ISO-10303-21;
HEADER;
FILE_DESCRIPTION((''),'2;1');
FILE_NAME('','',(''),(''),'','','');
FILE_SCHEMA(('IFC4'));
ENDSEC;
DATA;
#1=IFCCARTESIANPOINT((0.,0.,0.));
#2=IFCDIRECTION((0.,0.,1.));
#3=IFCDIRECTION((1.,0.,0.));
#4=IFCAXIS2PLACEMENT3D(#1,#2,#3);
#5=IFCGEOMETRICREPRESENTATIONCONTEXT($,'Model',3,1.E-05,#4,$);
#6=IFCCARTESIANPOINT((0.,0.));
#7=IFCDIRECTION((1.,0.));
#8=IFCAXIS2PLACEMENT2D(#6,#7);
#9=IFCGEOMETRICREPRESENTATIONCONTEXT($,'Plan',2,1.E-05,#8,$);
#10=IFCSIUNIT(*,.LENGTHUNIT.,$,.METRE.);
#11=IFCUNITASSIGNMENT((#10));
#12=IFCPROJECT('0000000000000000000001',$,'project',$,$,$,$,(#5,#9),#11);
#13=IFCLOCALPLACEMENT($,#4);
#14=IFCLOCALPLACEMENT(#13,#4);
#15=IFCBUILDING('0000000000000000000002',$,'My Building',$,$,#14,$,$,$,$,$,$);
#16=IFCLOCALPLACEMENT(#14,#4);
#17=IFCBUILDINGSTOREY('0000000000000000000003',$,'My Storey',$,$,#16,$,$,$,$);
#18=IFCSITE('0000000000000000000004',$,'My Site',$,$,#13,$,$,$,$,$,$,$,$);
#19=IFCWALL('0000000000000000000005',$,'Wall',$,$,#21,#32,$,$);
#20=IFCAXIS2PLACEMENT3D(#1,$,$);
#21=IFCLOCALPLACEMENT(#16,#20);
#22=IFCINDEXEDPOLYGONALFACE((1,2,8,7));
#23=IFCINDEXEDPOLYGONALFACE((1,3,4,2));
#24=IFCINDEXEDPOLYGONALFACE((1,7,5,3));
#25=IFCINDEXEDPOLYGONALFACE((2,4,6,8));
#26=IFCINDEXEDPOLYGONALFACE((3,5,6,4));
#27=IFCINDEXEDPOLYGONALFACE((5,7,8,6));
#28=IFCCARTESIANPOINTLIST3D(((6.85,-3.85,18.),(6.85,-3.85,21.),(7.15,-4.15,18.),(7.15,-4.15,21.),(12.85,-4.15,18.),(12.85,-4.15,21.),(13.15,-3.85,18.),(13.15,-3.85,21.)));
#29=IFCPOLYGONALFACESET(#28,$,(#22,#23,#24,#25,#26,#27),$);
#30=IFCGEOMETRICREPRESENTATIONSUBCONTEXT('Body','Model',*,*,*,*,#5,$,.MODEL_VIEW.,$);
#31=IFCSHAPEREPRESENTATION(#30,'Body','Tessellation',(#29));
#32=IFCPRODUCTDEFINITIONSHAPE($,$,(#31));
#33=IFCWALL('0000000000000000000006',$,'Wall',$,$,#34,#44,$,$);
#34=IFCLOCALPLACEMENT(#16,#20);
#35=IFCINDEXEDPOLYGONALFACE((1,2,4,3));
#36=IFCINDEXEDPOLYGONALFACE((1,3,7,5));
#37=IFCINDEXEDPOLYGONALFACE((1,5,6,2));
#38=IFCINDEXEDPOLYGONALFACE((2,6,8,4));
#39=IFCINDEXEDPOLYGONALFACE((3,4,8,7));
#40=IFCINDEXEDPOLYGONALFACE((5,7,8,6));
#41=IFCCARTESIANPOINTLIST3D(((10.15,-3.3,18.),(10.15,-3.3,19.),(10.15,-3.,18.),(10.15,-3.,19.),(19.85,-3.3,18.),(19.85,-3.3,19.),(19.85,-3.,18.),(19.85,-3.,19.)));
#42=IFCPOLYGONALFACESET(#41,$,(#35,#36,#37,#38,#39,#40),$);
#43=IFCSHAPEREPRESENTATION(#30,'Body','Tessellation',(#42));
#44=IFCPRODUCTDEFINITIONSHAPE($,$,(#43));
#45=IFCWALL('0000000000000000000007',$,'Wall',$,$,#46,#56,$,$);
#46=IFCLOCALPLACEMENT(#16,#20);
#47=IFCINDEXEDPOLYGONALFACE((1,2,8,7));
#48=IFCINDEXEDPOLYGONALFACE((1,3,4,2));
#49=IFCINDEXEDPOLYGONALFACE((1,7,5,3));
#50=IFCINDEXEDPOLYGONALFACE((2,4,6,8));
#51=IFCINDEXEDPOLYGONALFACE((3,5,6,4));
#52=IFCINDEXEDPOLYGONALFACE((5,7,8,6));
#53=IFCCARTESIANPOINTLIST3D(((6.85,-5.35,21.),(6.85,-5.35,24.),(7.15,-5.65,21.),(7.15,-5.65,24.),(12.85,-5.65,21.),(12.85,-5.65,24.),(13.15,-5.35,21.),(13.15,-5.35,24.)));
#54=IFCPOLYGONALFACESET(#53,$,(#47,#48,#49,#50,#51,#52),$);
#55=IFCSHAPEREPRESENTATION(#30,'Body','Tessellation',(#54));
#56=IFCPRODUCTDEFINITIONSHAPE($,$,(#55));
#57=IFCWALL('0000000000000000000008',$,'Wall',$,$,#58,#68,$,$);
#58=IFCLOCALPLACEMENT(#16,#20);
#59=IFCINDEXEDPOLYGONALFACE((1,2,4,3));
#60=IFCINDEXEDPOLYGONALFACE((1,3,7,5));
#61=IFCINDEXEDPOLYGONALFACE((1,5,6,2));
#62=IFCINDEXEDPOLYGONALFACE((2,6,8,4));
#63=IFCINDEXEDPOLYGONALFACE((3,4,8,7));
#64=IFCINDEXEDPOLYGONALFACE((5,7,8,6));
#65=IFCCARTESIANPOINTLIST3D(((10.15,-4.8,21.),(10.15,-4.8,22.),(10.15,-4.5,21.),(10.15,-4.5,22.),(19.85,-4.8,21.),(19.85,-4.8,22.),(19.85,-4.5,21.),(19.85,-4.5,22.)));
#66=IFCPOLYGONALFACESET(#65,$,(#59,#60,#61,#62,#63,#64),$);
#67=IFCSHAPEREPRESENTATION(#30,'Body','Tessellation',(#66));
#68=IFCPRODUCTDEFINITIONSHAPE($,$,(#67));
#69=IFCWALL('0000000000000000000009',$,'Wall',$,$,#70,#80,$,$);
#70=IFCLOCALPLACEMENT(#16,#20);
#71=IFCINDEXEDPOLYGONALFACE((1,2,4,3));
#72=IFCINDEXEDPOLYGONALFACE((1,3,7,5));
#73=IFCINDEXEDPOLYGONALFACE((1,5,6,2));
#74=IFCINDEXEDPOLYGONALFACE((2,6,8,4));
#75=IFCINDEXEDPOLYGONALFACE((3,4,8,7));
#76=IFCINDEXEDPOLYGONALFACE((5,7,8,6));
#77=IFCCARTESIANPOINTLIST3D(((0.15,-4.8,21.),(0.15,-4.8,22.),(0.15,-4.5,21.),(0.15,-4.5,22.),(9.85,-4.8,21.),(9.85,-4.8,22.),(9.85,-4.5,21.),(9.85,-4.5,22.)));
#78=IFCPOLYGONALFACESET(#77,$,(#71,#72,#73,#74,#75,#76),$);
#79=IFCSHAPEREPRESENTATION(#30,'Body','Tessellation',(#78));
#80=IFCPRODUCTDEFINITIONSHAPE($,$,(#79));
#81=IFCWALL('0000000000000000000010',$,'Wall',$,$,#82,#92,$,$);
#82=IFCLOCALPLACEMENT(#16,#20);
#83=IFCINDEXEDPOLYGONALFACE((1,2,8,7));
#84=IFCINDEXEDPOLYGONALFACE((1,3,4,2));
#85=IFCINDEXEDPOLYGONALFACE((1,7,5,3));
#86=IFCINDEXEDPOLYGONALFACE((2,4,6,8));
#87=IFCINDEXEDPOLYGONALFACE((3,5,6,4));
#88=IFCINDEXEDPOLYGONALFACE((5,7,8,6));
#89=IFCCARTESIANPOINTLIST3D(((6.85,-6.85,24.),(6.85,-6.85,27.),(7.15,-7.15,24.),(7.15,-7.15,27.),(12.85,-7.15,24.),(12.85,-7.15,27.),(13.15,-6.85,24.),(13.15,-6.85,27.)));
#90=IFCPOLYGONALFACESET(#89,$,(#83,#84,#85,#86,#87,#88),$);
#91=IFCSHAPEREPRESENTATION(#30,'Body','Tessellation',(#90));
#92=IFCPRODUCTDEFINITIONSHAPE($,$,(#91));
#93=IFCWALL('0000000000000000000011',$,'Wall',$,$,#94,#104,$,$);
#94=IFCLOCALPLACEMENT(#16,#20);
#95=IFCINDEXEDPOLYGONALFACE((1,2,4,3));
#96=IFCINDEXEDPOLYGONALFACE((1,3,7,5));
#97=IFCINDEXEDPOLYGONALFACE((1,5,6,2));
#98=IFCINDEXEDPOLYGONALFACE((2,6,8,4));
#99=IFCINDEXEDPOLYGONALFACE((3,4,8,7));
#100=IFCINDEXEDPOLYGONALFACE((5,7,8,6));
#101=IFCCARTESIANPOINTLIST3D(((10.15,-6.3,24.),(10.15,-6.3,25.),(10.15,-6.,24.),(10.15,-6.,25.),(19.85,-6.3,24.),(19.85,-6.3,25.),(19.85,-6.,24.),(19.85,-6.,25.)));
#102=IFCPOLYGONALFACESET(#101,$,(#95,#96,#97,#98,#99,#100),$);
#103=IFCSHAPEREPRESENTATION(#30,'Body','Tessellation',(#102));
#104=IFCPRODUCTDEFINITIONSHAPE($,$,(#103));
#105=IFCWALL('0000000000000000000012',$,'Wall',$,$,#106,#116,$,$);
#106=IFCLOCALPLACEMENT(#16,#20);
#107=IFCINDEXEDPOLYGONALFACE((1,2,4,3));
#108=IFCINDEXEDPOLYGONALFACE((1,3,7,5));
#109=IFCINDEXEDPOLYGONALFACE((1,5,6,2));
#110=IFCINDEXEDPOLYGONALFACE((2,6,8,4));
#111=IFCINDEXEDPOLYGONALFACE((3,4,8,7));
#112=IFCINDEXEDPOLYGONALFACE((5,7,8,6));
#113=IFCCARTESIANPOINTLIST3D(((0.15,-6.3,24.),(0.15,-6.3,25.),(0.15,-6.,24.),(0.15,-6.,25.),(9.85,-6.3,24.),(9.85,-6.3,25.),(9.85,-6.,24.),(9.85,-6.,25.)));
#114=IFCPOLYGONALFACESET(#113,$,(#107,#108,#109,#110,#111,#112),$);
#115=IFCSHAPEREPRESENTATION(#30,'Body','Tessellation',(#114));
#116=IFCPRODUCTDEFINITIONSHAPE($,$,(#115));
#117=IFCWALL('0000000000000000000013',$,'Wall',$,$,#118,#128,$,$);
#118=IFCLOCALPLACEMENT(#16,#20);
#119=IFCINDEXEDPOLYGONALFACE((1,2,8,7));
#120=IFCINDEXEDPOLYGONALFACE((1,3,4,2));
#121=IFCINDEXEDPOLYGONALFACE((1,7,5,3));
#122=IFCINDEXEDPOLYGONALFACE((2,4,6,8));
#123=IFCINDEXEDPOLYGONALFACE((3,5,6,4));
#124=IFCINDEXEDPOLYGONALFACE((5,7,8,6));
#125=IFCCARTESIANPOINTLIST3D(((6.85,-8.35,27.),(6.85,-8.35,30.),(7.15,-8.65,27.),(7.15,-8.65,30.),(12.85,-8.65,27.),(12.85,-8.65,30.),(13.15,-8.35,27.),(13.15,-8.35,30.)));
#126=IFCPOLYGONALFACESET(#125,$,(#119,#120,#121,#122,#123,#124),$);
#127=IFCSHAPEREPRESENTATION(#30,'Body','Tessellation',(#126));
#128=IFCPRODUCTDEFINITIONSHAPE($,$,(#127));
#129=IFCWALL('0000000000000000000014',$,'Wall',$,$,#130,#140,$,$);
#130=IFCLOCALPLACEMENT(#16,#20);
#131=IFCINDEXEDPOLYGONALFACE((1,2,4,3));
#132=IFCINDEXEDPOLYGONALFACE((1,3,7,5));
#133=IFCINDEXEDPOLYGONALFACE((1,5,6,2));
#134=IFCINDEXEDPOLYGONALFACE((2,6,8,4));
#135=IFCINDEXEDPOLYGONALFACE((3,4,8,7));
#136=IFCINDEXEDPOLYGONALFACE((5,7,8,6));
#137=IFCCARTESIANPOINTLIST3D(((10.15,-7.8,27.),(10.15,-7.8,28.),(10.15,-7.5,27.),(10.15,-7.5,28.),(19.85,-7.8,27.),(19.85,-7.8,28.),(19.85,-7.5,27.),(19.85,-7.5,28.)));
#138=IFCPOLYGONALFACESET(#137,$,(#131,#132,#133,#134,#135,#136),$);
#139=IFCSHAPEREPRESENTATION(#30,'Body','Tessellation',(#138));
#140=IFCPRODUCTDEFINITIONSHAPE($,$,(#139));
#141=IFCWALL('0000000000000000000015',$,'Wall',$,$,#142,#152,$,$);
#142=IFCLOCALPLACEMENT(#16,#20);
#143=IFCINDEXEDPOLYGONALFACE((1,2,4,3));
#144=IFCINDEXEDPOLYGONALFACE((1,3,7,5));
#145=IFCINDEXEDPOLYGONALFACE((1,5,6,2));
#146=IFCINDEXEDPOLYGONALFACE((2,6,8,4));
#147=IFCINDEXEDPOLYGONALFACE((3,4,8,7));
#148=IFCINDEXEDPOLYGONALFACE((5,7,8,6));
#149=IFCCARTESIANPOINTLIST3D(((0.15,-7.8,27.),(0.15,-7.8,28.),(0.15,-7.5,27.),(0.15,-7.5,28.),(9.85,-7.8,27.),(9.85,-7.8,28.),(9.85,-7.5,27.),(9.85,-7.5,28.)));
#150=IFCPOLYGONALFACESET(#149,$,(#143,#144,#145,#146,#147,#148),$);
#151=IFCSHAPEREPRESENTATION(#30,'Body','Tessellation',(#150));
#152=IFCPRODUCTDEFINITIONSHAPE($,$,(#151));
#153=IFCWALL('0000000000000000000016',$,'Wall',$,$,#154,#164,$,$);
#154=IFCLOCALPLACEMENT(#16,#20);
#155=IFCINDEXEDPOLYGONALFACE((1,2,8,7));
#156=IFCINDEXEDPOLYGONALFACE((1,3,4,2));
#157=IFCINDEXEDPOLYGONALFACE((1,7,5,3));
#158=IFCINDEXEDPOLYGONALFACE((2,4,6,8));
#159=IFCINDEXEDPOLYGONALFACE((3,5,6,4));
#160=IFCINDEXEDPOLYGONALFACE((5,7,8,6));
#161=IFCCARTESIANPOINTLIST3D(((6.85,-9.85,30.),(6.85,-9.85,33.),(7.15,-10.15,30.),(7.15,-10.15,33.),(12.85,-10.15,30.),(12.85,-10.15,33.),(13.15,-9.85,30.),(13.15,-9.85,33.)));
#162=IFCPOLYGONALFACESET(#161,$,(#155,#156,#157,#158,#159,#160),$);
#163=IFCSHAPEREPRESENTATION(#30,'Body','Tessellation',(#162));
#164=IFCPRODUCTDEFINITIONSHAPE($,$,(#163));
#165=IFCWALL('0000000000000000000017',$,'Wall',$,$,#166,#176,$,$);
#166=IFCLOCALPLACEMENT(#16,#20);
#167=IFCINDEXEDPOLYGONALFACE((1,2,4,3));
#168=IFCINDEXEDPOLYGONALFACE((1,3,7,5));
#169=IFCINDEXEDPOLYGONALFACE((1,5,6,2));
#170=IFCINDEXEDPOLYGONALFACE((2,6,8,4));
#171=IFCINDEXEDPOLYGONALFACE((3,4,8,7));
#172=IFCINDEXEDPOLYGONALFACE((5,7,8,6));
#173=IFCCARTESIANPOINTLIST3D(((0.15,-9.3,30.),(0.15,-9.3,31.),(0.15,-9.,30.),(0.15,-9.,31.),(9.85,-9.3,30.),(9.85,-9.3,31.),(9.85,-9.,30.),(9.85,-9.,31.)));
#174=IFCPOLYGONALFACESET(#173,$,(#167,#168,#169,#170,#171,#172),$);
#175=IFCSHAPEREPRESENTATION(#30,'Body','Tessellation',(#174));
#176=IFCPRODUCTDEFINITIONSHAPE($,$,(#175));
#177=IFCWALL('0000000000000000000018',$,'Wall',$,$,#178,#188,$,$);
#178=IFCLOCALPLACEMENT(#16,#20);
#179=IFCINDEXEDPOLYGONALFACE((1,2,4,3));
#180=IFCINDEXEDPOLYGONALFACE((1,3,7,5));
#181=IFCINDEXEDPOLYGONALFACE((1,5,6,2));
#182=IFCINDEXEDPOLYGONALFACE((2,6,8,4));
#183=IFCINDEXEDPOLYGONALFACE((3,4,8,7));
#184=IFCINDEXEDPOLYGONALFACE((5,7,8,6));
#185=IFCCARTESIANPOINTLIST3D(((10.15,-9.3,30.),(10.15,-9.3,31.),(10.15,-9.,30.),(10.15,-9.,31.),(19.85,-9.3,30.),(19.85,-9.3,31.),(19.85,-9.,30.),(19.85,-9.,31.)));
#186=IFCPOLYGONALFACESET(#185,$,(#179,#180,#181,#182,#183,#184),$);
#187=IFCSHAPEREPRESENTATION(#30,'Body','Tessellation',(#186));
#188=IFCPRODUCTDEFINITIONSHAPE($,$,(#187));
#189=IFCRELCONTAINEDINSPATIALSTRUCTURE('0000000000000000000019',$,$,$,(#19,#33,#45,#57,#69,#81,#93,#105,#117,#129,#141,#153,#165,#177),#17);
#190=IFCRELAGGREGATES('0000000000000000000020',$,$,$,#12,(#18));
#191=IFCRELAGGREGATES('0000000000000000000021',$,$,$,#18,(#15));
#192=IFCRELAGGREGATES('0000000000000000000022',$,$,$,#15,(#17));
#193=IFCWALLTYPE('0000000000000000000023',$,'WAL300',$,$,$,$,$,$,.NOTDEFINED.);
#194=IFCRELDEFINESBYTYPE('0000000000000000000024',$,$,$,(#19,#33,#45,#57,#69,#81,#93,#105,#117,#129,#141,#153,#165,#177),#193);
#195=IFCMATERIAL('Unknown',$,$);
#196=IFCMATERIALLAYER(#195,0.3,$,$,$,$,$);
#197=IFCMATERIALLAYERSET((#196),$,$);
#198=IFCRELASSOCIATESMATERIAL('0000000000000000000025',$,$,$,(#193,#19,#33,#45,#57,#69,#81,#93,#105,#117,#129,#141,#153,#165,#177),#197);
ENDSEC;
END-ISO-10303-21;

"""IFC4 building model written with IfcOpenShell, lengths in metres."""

from ifc_helpers import new_model, si_unit, frame, origin_with_axes, origin_2d_with_axis, place, context, subcontext, project, spatial, line, indexed_curve, outline, extrude, material, layer, layer_set, layer_usage, type_object, element, save


model = new_model("IFC4")

# Units and contexts
model_context = context("Model", 3, precision=1e-05, world=origin_with_axes())
plan_context = context("Plan", 2, precision=1e-05, world=origin_2d_with_axis())
body_context = subcontext(model_context, "Body", "Model", "MODEL_VIEW")
ifc_project = project(units=[si_unit("LENGTHUNIT", "METRE")], contexts=[model_context, plan_context])

# Site, building, storey
site_placement = place(None, origin_with_axes())
site = spatial("IfcSite", under=ifc_project, at=site_placement, Name="My Site")
building_placement = place(site_placement, origin_with_axes())
building = spatial("IfcBuilding", under=site, at=building_placement, Name="My Building")
storey_placement = place(building_placement, origin_with_axes())
storey = spatial("IfcBuildingStorey", under=building, at=storey_placement, Name="My Storey")

# Walls
ifc_material = material(Name="Unknown")
ifc_layer = layer(ifc_material, 0.3)
ifc_layer_set = layer_set([ifc_layer])
wall_type = type_object("IfcWallType", Name="WAL300", PredefinedType="NOTDEFINED", material=ifc_layer_set)
ifc_layer_usage_1 = layer_usage(ifc_layer_set, "AXIS2", "POSITIVE", -0.15)
wall_1_placement = place(storey_placement, frame((7.0, -4.0, 18.0), z_axis=(0.0, 0.0, 1.0), x_axis=(1.0, 0.0, 0.0)))
element("IfcWall", 1, at=wall_1_placement, inside=storey, type_object=wall_type, material=ifc_layer_usage_1, Name="Wall", context=body_context, shape_type="SweptSolid", body=[
    extrude(outline(indexed_curve([(0.15, -0.15), (-0.15, 0.15), (6.15, 0.15), (5.85, -0.15)], segments=[line(1, 2, 3, 4, 1)])), origin_with_axes(), (0.0, 0.0, 1.0), 3.0),
])
ifc_layer_usage_2 = layer_usage(ifc_layer_set, "AXIS2", "POSITIVE", -0.3)
wall_2_placement = place(storey_placement, frame((10.15, -3.0, 18.0), z_axis=(0.0, 0.0, 1.0), x_axis=(1.0, 0.0, 0.0)))
element("IfcWall", 2, at=wall_2_placement, inside=storey, type_object=wall_type, material=ifc_layer_usage_2, Name="Wall", context=body_context, shape_type="SweptSolid", body=[
    extrude(outline(indexed_curve([(0.0, -0.3), (0.0, 0.0), (9.7, 0.0), (9.7, -0.3)], segments=[line(1, 2, 3, 4, 1)])), origin_with_axes(), (0.0, 0.0, 1.0), 1.0),
])
ifc_layer_usage_3 = layer_usage(ifc_layer_set, "AXIS2", "POSITIVE", -0.15)
wall_3_placement = place(storey_placement, frame((7.0, -5.5, 21.0), z_axis=(0.0, 0.0, 1.0), x_axis=(1.0, 0.0, 0.0)))
element("IfcWall", 3, at=wall_3_placement, inside=storey, type_object=wall_type, material=ifc_layer_usage_3, Name="Wall", context=body_context, shape_type="SweptSolid", body=[
    extrude(outline(indexed_curve([(0.15, -0.15), (-0.15, 0.15), (6.15, 0.15), (5.85, -0.15)], segments=[line(1, 2, 3, 4, 1)])), origin_with_axes(), (0.0, 0.0, 1.0), 3.0),
])
ifc_layer_usage_4 = layer_usage(ifc_layer_set, "AXIS2", "POSITIVE", -0.3)
wall_4_placement = place(storey_placement, frame((10.15, -4.5, 21.0), z_axis=(0.0, 0.0, 1.0), x_axis=(1.0, 0.0, 0.0)))
element("IfcWall", 4, at=wall_4_placement, inside=storey, type_object=wall_type, material=ifc_layer_usage_4, Name="Wall", context=body_context, shape_type="SweptSolid", body=[
    extrude(outline(indexed_curve([(0.0, -0.3), (0.0, 0.0), (9.7, 0.0), (9.7, -0.3)], segments=[line(1, 2, 3, 4, 1)])), origin_with_axes(), (0.0, 0.0, 1.0), 1.0),
])
ifc_layer_usage_5 = layer_usage(ifc_layer_set, "AXIS2", "POSITIVE", -0.3)
wall_5_placement = place(storey_placement, frame((0.15, -4.5, 21.0), z_axis=(0.0, 0.0, 1.0), x_axis=(1.0, 0.0, 0.0)))
element("IfcWall", 5, at=wall_5_placement, inside=storey, type_object=wall_type, material=ifc_layer_usage_5, Name="Wall", context=body_context, shape_type="SweptSolid", body=[
    extrude(outline(indexed_curve([(0.0, -0.3), (0.0, 0.0), (9.7, 0.0), (9.7, -0.3)], segments=[line(1, 2, 3, 4, 1)])), origin_with_axes(), (0.0, 0.0, 1.0), 1.0),
])
ifc_layer_usage_6 = layer_usage(ifc_layer_set, "AXIS2", "POSITIVE", -0.15)
wall_6_placement = place(storey_placement, frame((7.0, -7.0, 24.0), z_axis=(0.0, 0.0, 1.0), x_axis=(1.0, 0.0, 0.0)))
element("IfcWall", 6, at=wall_6_placement, inside=storey, type_object=wall_type, material=ifc_layer_usage_6, Name="Wall", context=body_context, shape_type="SweptSolid", body=[
    extrude(outline(indexed_curve([(0.15, -0.15), (-0.15, 0.15), (6.15, 0.15), (5.85, -0.15)], segments=[line(1, 2, 3, 4, 1)])), origin_with_axes(), (0.0, 0.0, 1.0), 3.0),
])
ifc_layer_usage_7 = layer_usage(ifc_layer_set, "AXIS2", "POSITIVE", -0.3)
wall_7_placement = place(storey_placement, frame((10.15, -6.0, 24.0), z_axis=(0.0, 0.0, 1.0), x_axis=(1.0, 0.0, 0.0)))
element("IfcWall", 7, at=wall_7_placement, inside=storey, type_object=wall_type, material=ifc_layer_usage_7, Name="Wall", context=body_context, shape_type="SweptSolid", body=[
    extrude(outline(indexed_curve([(0.0, -0.3), (0.0, 0.0), (9.7, 0.0), (9.7, -0.3)], segments=[line(1, 2, 3, 4, 1)])), origin_with_axes(), (0.0, 0.0, 1.0), 1.0),
])
ifc_layer_usage_8 = layer_usage(ifc_layer_set, "AXIS2", "POSITIVE", -0.3)
wall_8_placement = place(storey_placement, frame((0.15, -6.0, 24.0), z_axis=(0.0, 0.0, 1.0), x_axis=(1.0, 0.0, 0.0)))
element("IfcWall", 8, at=wall_8_placement, inside=storey, type_object=wall_type, material=ifc_layer_usage_8, Name="Wall", context=body_context, shape_type="SweptSolid", body=[
    extrude(outline(indexed_curve([(0.0, -0.3), (0.0, 0.0), (9.7, 0.0), (9.7, -0.3)], segments=[line(1, 2, 3, 4, 1)])), origin_with_axes(), (0.0, 0.0, 1.0), 1.0),
])
ifc_layer_usage_9 = layer_usage(ifc_layer_set, "AXIS2", "POSITIVE", -0.15)
wall_9_placement = place(storey_placement, frame((7.0, -8.5, 27.0), z_axis=(0.0, 0.0, 1.0), x_axis=(1.0, 0.0, 0.0)))
element("IfcWall", 9, at=wall_9_placement, inside=storey, type_object=wall_type, material=ifc_layer_usage_9, Name="Wall", context=body_context, shape_type="SweptSolid", body=[
    extrude(outline(indexed_curve([(0.15, -0.15), (-0.15, 0.15), (6.15, 0.15), (5.85, -0.15)], segments=[line(1, 2, 3, 4, 1)])), origin_with_axes(), (0.0, 0.0, 1.0), 3.0),
])
ifc_layer_usage_10 = layer_usage(ifc_layer_set, "AXIS2", "POSITIVE", -0.3)
wall_10_placement = place(storey_placement, frame((10.15, -7.5, 27.0), z_axis=(0.0, 0.0, 1.0), x_axis=(1.0, 0.0, 0.0)))
element("IfcWall", 10, at=wall_10_placement, inside=storey, type_object=wall_type, material=ifc_layer_usage_10, Name="Wall", context=body_context, shape_type="SweptSolid", body=[
    extrude(outline(indexed_curve([(0.0, -0.3), (0.0, 0.0), (9.7, 0.0), (9.7, -0.3)], segments=[line(1, 2, 3, 4, 1)])), origin_with_axes(), (0.0, 0.0, 1.0), 1.0),
])
ifc_layer_usage_11 = layer_usage(ifc_layer_set, "AXIS2", "POSITIVE", -0.3)
wall_11_placement = place(storey_placement, frame((0.15, -7.5, 27.0), z_axis=(0.0, 0.0, 1.0), x_axis=(1.0, 0.0, 0.0)))
element("IfcWall", 11, at=wall_11_placement, inside=storey, type_object=wall_type, material=ifc_layer_usage_11, Name="Wall", context=body_context, shape_type="SweptSolid", body=[
    extrude(outline(indexed_curve([(0.0, -0.3), (0.0, 0.0), (9.7, 0.0), (9.7, -0.3)], segments=[line(1, 2, 3, 4, 1)])), origin_with_axes(), (0.0, 0.0, 1.0), 1.0),
])
ifc_layer_usage_12 = layer_usage(ifc_layer_set, "AXIS2", "POSITIVE", -0.15)
wall_12_placement = place(storey_placement, frame((7.0, -10.0, 30.0), z_axis=(0.0, 0.0, 1.0), x_axis=(1.0, 0.0, 0.0)))
element("IfcWall", 12, at=wall_12_placement, inside=storey, type_object=wall_type, material=ifc_layer_usage_12, Name="Wall", context=body_context, shape_type="SweptSolid", body=[
    extrude(outline(indexed_curve([(0.15, -0.15), (-0.15, 0.15), (6.15, 0.15), (5.85, -0.15)], segments=[line(1, 2, 3, 4, 1)])), origin_with_axes(), (0.0, 0.0, 1.0), 3.0),
])
ifc_layer_usage_13 = layer_usage(ifc_layer_set, "AXIS2", "POSITIVE", -0.3)
wall_13_placement = place(storey_placement, frame((0.15, -9.0, 30.0), z_axis=(0.0, 0.0, 1.0), x_axis=(1.0, 0.0, 0.0)))
element("IfcWall", 13, at=wall_13_placement, inside=storey, type_object=wall_type, material=ifc_layer_usage_13, Name="Wall", context=body_context, shape_type="SweptSolid", body=[
    extrude(outline(indexed_curve([(0.0, -0.3), (0.0, 0.0), (9.7, 0.0), (9.7, -0.3)], segments=[line(1, 2, 3, 4, 1)])), origin_with_axes(), (0.0, 0.0, 1.0), 1.0),
])
ifc_layer_usage_14 = layer_usage(ifc_layer_set, "AXIS2", "POSITIVE", -0.3)
wall_14_placement = place(storey_placement, frame((10.15, -9.0, 30.0), z_axis=(0.0, 0.0, 1.0), x_axis=(1.0, 0.0, 0.0)))
element("IfcWall", 14, at=wall_14_placement, inside=storey, type_object=wall_type, material=ifc_layer_usage_14, Name="Wall", context=body_context, shape_type="SweptSolid", body=[
    extrude(outline(indexed_curve([(0.0, -0.3), (0.0, 0.0), (9.7, 0.0), (9.7, -0.3)], segments=[line(1, 2, 3, 4, 1)])), origin_with_axes(), (0.0, 0.0, 1.0), 1.0),
])

save(model, "model.ifc")
